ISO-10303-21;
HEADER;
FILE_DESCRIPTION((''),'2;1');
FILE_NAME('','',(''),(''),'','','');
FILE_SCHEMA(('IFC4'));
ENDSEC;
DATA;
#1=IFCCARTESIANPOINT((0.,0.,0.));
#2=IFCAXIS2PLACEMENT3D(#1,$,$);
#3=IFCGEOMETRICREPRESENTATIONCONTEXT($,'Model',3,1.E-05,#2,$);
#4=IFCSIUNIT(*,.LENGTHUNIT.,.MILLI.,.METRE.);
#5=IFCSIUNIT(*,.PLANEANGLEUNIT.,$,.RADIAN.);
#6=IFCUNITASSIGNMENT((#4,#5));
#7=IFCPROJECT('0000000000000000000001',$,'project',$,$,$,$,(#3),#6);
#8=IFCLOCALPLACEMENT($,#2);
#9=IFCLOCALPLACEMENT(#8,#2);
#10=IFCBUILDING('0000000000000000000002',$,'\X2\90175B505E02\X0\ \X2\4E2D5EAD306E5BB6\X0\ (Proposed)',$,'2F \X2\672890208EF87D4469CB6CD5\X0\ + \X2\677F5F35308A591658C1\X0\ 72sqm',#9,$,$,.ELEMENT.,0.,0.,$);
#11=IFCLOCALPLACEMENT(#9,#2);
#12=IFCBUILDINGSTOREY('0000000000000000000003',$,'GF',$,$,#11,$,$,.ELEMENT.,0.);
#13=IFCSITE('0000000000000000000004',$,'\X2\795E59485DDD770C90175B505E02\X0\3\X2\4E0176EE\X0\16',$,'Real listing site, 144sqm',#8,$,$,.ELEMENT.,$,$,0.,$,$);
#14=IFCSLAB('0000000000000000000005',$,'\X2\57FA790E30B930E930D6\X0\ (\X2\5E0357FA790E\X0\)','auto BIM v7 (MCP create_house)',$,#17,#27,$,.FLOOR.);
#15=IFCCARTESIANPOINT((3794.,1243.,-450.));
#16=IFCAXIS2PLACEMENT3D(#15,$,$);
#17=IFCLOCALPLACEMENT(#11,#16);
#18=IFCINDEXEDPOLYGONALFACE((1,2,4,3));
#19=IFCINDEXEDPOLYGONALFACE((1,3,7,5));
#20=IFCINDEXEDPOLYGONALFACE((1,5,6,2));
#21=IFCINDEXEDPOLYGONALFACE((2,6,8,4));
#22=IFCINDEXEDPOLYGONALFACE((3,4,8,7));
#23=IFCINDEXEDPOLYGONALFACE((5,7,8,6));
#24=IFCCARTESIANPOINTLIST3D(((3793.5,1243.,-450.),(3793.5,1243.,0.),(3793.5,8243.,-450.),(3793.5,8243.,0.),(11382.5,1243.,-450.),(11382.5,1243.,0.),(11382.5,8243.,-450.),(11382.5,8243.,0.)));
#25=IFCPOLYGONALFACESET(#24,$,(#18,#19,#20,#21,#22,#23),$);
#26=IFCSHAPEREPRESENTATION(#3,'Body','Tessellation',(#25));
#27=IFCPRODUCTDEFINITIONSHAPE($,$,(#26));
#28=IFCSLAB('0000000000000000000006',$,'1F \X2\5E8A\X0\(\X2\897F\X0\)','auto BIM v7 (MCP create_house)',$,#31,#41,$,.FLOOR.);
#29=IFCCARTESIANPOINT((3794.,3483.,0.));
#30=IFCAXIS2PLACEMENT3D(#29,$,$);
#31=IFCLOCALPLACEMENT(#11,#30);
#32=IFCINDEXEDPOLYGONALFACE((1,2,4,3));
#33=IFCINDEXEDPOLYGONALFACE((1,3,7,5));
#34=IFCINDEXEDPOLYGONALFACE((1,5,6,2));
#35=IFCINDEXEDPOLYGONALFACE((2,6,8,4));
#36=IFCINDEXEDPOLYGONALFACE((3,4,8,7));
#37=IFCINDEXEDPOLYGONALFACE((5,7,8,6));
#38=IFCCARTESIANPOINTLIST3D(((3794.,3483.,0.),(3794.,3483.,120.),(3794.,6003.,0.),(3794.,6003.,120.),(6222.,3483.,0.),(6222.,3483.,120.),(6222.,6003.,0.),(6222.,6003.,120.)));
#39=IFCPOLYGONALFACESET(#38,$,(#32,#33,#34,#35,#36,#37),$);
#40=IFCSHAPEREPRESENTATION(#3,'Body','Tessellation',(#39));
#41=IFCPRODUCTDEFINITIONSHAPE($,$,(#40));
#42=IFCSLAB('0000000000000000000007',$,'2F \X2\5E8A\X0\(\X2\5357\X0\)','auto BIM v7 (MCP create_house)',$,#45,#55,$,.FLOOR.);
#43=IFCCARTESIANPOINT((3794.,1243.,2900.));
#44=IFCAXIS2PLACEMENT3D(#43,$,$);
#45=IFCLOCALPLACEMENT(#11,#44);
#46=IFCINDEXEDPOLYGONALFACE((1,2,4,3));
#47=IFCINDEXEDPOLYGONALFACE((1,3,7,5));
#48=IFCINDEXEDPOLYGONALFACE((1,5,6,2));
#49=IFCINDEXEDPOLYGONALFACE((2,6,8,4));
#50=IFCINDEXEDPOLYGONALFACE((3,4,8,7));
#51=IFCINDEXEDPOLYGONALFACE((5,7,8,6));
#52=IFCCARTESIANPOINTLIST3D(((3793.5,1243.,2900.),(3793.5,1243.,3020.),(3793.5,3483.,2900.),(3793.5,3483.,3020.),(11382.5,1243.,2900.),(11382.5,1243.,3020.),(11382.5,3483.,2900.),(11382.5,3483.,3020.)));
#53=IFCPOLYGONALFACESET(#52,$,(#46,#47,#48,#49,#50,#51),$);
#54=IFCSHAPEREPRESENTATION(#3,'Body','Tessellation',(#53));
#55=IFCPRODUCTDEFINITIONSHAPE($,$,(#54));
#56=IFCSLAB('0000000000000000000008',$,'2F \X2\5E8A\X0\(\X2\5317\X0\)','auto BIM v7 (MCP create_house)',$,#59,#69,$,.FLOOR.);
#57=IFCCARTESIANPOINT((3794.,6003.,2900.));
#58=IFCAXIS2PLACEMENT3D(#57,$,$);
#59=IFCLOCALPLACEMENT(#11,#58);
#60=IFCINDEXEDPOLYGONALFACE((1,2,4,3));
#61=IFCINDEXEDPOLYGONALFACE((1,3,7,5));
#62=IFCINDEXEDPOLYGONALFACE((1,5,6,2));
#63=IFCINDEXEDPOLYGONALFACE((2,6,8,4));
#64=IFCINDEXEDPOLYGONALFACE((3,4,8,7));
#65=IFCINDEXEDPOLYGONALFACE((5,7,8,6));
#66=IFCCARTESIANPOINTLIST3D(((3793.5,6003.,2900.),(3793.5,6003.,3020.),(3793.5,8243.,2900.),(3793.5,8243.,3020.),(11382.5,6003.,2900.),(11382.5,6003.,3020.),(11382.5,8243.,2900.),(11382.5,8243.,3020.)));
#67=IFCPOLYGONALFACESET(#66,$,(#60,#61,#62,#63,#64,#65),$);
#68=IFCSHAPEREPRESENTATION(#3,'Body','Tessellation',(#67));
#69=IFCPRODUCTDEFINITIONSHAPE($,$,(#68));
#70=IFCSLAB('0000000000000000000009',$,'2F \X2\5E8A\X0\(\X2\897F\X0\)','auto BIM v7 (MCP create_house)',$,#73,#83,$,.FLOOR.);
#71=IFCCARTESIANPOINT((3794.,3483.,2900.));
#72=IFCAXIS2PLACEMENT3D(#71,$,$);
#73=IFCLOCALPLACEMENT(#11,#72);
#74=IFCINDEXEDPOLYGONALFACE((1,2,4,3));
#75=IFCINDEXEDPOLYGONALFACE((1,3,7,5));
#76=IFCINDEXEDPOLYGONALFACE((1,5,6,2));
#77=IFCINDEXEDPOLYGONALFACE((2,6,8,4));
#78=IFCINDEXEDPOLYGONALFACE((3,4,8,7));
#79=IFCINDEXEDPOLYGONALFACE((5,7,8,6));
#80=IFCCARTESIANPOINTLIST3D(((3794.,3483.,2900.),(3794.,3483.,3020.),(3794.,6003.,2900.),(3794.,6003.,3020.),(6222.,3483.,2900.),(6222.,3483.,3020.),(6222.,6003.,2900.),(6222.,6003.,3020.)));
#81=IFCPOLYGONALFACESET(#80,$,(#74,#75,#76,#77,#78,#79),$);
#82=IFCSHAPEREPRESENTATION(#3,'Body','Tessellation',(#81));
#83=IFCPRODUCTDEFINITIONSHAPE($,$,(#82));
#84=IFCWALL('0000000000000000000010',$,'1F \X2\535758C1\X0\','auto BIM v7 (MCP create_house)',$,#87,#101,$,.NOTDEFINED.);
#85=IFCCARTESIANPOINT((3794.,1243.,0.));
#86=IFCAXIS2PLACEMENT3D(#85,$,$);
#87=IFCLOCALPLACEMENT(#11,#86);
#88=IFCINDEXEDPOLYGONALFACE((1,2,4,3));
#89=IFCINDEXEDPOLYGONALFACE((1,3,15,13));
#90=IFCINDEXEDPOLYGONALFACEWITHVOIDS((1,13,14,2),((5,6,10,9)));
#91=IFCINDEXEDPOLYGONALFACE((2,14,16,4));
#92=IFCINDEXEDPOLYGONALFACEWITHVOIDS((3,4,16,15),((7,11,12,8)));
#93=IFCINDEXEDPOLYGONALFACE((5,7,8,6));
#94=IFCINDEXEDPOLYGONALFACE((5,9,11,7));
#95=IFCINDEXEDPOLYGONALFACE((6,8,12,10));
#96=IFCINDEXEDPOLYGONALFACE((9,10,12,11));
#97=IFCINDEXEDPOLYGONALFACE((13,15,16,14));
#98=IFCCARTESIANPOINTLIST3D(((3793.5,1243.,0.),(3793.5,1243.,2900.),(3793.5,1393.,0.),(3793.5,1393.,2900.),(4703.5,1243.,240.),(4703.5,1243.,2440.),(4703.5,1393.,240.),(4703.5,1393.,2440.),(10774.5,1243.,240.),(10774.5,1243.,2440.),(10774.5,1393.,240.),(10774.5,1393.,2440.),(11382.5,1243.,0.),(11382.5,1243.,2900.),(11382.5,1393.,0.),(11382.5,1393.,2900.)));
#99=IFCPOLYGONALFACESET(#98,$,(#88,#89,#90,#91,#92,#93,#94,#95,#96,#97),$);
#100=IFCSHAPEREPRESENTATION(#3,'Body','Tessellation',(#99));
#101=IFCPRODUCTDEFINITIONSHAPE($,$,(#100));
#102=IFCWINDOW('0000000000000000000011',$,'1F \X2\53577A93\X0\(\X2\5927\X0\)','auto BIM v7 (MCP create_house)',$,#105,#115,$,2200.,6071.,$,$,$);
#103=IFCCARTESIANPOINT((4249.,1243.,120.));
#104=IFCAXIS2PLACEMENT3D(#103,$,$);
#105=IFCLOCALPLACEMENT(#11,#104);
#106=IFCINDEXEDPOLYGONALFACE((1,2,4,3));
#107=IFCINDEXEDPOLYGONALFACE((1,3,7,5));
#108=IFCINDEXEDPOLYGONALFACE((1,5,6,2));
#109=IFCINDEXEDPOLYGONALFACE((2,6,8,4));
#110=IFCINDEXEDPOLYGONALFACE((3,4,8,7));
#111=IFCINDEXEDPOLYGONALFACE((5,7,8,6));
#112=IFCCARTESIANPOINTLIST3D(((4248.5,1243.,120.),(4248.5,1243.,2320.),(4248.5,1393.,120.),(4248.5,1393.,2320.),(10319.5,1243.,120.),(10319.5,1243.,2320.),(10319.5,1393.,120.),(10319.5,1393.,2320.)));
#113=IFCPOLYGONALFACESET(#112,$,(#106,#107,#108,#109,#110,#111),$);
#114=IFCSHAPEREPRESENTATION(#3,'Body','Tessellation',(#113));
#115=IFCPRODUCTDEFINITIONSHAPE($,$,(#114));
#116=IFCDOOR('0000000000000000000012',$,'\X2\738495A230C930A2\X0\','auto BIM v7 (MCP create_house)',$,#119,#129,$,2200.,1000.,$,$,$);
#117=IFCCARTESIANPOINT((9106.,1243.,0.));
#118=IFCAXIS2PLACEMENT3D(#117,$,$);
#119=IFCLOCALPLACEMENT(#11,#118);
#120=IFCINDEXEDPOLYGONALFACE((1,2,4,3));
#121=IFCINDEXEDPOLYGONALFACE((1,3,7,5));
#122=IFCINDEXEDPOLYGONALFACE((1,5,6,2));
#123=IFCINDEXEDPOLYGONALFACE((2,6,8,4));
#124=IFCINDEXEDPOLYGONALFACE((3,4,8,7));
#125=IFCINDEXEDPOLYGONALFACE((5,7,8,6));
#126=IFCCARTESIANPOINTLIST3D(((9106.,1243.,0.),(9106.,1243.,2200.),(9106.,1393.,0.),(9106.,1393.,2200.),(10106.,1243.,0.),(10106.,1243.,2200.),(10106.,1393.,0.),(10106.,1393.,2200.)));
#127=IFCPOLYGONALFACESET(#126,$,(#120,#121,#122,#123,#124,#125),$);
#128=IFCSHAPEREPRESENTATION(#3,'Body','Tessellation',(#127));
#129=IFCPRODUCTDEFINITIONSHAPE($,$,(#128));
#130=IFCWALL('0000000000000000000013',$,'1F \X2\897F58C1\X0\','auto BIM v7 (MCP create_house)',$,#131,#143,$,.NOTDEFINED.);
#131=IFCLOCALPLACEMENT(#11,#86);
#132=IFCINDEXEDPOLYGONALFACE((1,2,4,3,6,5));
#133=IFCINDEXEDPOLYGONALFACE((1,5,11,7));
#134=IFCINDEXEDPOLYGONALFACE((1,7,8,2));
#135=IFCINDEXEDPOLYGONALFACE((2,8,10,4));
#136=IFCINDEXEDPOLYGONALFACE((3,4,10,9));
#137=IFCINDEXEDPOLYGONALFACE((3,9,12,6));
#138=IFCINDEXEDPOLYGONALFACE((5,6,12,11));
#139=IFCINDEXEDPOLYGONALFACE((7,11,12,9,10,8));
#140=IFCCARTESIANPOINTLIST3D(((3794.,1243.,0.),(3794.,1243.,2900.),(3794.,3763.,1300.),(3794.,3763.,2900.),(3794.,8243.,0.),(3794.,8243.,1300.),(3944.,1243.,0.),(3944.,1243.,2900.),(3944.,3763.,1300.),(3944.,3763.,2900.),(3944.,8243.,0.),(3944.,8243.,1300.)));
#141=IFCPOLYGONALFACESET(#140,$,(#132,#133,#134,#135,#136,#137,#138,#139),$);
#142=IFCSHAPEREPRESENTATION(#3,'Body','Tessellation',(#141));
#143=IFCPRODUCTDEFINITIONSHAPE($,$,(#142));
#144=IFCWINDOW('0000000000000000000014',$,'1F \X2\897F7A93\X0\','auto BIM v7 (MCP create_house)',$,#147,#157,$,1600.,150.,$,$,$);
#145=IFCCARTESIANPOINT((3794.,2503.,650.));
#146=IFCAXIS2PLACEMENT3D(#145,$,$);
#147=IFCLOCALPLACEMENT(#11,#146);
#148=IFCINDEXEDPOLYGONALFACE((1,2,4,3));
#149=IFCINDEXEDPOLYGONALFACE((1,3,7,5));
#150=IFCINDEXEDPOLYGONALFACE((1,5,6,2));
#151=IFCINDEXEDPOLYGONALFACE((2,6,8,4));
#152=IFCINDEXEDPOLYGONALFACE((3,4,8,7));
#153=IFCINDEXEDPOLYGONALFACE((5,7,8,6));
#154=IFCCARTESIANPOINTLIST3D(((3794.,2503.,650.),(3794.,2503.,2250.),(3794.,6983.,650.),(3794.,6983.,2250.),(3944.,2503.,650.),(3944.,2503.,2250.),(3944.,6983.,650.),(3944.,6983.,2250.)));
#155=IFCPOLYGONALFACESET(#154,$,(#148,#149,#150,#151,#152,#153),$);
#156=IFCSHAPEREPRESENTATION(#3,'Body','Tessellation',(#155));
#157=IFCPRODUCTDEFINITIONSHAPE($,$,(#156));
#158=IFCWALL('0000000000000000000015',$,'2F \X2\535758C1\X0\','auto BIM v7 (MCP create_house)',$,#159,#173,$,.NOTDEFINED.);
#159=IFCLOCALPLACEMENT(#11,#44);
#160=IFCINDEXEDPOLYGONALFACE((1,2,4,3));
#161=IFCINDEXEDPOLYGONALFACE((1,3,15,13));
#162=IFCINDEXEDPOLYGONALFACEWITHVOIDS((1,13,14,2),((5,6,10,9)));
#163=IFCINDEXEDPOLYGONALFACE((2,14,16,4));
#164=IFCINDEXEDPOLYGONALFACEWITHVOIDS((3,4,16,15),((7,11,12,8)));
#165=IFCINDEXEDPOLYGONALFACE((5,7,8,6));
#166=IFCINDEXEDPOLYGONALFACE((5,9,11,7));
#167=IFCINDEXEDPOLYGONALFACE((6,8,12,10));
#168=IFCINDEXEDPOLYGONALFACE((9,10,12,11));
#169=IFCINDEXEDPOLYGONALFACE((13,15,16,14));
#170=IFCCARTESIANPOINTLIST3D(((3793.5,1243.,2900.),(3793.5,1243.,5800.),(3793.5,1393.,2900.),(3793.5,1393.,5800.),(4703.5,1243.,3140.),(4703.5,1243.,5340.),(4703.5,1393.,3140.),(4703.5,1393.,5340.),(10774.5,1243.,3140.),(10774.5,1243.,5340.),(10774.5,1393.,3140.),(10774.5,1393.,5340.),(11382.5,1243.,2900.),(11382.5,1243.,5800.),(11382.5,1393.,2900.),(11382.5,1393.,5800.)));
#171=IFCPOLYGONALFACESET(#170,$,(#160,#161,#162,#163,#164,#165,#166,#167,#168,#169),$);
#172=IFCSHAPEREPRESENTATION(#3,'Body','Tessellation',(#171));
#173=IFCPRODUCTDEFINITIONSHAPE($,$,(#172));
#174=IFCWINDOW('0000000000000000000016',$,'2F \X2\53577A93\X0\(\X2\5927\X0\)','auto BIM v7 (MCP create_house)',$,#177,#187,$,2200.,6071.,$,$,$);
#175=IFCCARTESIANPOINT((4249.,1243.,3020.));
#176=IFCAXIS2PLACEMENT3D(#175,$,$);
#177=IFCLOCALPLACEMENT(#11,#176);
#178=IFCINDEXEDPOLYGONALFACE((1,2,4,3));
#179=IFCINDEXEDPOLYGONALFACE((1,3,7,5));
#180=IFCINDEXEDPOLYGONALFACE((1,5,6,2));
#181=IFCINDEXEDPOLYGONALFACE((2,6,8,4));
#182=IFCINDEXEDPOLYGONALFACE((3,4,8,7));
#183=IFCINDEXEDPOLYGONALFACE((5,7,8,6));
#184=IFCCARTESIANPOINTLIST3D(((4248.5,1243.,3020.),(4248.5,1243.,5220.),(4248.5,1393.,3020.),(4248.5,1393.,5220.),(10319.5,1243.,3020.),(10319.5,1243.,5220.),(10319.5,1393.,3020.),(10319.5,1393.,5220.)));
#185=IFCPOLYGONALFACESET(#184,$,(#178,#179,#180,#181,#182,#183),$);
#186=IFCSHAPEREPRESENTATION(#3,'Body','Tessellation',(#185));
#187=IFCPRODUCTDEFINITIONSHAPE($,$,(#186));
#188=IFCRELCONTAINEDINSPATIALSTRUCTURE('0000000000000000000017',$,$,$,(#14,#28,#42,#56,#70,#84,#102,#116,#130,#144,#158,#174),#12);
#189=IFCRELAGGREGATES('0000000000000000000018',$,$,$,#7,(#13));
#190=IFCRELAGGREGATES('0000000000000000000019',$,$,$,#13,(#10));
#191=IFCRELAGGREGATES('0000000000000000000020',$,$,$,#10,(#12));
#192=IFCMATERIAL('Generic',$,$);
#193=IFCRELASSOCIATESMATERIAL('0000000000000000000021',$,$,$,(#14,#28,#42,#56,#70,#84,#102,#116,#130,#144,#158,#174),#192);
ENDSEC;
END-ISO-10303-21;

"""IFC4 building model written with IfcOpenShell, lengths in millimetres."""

from ifc_helpers import new_model, si_unit, frame, frame_2d, origin, place, context, project, spatial, rectangle, extrude, material, element, fill, save


model = new_model("IFC4")

# Units and contexts
model_context = context("Model", 3, precision=1e-05, world=origin())
ifc_project = project(units=[si_unit("LENGTHUNIT", "METRE", prefix="MILLI"), si_unit("PLANEANGLEUNIT", "RADIAN")], contexts=[model_context])

# Site, building, storey
site_placement = place(None, origin())
site = spatial("IfcSite", under=ifc_project, at=site_placement, Name="神奈川県逗子市3丁目16", ObjectType="Real listing site, 144sqm", CompositionType="ELEMENT", RefElevation=0.0)
building_placement = place(site_placement, origin())
building = spatial("IfcBuilding", under=site, at=building_placement, Name="逗子市 中庭の家 (Proposed)", ObjectType="2F 木造軸組構法 + 板張り外壁 72sqm", CompositionType="ELEMENT", ElevationOfRefHeight=0.0, ElevationOfTerrain=0.0)
storey_placement = place(building_placement, origin())
storey = spatial("IfcBuildingStorey", under=building, at=storey_placement, Name="GF", CompositionType="ELEMENT", Elevation=0.0)

# Slabs
ifc_material = material(Name="Generic")
slab_1_placement = place(storey_placement, frame((3794.0, 1243.0, -450.0)))
element("IfcSlab", 1, at=slab_1_placement, inside=storey, material=ifc_material, Name="基礎スラブ (布基礎)", Description="auto BIM v7 (MCP create_house)", PredefinedType="FLOOR", context=model_context, shape_type="SweptSolid", body=[
    extrude(rectangle(XDim=7589.0, YDim=7000.0, at=frame_2d((3794.0, 3500.0))), frame((3794.0, 1243.0, -450.0)), (0.0, 0.0, 1.0), 450.0),
])
slab_2_placement = place(storey_placement, frame((3794.0, 3483.0, 0.0)))
element("IfcSlab", 2, at=slab_2_placement, inside=storey, material=ifc_material, Name="1F 床(西)", Description="auto BIM v7 (MCP create_house)", PredefinedType="FLOOR", context=model_context, shape_type="SweptSolid", body=[
    extrude(rectangle(XDim=2428.0, YDim=2520.0, at=frame_2d((1214.0, 1260.0))), frame((3794.0, 3483.0, 0.0)), (0.0, 0.0, 1.0), 120.0),
])
slab_3_placement = place(storey_placement, frame((3794.0, 1243.0, 2900.0)))
element("IfcSlab", 3, at=slab_3_placement, inside=storey, material=ifc_material, Name="2F 床(南)", Description="auto BIM v7 (MCP create_house)", PredefinedType="FLOOR", context=model_context, shape_type="SweptSolid", body=[
    extrude(rectangle(XDim=7589.0, YDim=2240.0, at=frame_2d((3794.0, 1120.0))), frame((3794.0, 1243.0, 2900.0)), (0.0, 0.0, 1.0), 120.0),
])
slab_4_placement = place(storey_placement, frame((3794.0, 6003.0, 2900.0)))
element("IfcSlab", 4, at=slab_4_placement, inside=storey, material=ifc_material, Name="2F 床(北)", Description="auto BIM v7 (MCP create_house)", PredefinedType="FLOOR", context=model_context, shape_type="SweptSolid", body=[
    extrude(rectangle(XDim=7589.0, YDim=2240.0, at=frame_2d((3794.0, 1120.0))), frame((3794.0, 6003.0, 2900.0)), (0.0, 0.0, 1.0), 120.0),
])
slab_5_placement = place(storey_placement, frame((3794.0, 3483.0, 2900.0)))
element("IfcSlab", 5, at=slab_5_placement, inside=storey, material=ifc_material, Name="2F 床(西)", Description="auto BIM v7 (MCP create_house)", PredefinedType="FLOOR", context=model_context, shape_type="SweptSolid", body=[
    extrude(rectangle(XDim=2428.0, YDim=2520.0, at=frame_2d((1214.0, 1260.0))), frame((3794.0, 3483.0, 2900.0)), (0.0, 0.0, 1.0), 120.0),
])

# Wall, openings, window, door
wall_1_placement = place(storey_placement, frame((3794.0, 1243.0, 0.0)))
wall_1 = element("IfcWall", 6, at=wall_1_placement, inside=storey, material=ifc_material, Name="1F 南壁", Description="auto BIM v7 (MCP create_house)", PredefinedType="NOTDEFINED", context=model_context, shape_type="SweptSolid", body=[
    extrude(rectangle(XDim=7589.0, YDim=150.0, at=frame_2d((3794.0, 75.0))), frame((3794.0, 1243.0, 0.0)), (0.0, 0.0, 1.0), 2900.0),
])
opening_1_placement = place(storey_placement, frame((4249.0, 1243.0, 120.0)))
opening_1 = element("IfcOpeningElement", 7, at=opening_1_placement, cuts=wall_1, PredefinedType="NOTDEFINED", context=model_context, shape_type="SweptSolid", body=[
    extrude(rectangle(XDim=6071.0, YDim=150.0, at=frame_2d((3035.0, 75.0))), frame((4249.0, 1243.0, 120.0)), (0.0, 0.0, 1.0), 2200.0),
])
opening_2_placement = place(storey_placement, frame((9106.0, 1243.0, 0.0)))
opening_2 = element("IfcOpeningElement", 8, at=opening_2_placement, cuts=wall_1, PredefinedType="NOTDEFINED", context=model_context, shape_type="SweptSolid", body=[
    extrude(rectangle(XDim=1000.0, YDim=150.0, at=frame_2d((500.0, 75.0))), frame((9106.0, 1243.0, 0.0)), (0.0, 0.0, 1.0), 2200.0),
])
window_1_placement = place(storey_placement, frame((4249.0, 1243.0, 120.0)))
window_1 = element("IfcWindow", 9, at=window_1_placement, inside=storey, material=ifc_material, Name="1F 南窓(大)", Description="auto BIM v7 (MCP create_house)", OverallHeight=2200.0, OverallWidth=6071.0, context=model_context, shape_type="SweptSolid", body=[
    extrude(rectangle(XDim=6071.0, YDim=150.0, at=frame_2d((3035.0, 75.0))), frame((4249.0, 1243.0, 120.0)), (0.0, 0.0, 1.0), 2200.0),
])
fill(opening_1, window_1)
door_placement = place(storey_placement, frame((9106.0, 1243.0, 0.0)))
door = element("IfcDoor", 10, at=door_placement, inside=storey, material=ifc_material, Name="玄関ドア", Description="auto BIM v7 (MCP create_house)", OverallHeight=2200.0, OverallWidth=1000.0, context=model_context, shape_type="SweptSolid", body=[
    extrude(rectangle(XDim=1000.0, YDim=150.0, at=frame_2d((500.0, 75.0))), frame((9106.0, 1243.0, 0.0)), (0.0, 0.0, 1.0), 2200.0),
])
fill(opening_2, door)

# Walls, openings, windows
wall_2_placement = place(storey_placement, frame((3794.0, 1243.0, 0.0)))
wall_2 = element("IfcWall", 11, at=wall_2_placement, inside=storey, material=ifc_material, Name="1F 西壁", Description="auto BIM v7 (MCP create_house)", PredefinedType="NOTDEFINED", context=model_context, shape_type="SweptSolid", body=[
    extrude(rectangle(XDim=150.0, YDim=7000.0, at=frame_2d((75.0, 3500.0))), frame((3794.0, 1243.0, 0.0)), (0.0, 0.0, 1.0), 2900.0),
])
opening_3_placement = place(storey_placement, frame((3794.0, 2503.0, 650.0)))
opening_3 = element("IfcOpeningElement", 12, at=opening_3_placement, cuts=wall_2, PredefinedType="NOTDEFINED", context=model_context, shape_type="SweptSolid", body=[
    extrude(rectangle(XDim=150.0, YDim=4480.0, at=frame_2d((75.0, 2240.0))), frame((3794.0, 2503.0, 650.0)), (0.0, 0.0, 1.0), 1600.0),
])
window_2_placement = place(storey_placement, frame((3794.0, 2503.0, 650.0)))
window_2 = element("IfcWindow", 13, at=window_2_placement, inside=storey, material=ifc_material, Name="1F 西窓", Description="auto BIM v7 (MCP create_house)", OverallHeight=1600.0, OverallWidth=150.0, context=model_context, shape_type="SweptSolid", body=[
    extrude(rectangle(XDim=150.0, YDim=4480.0, at=frame_2d((75.0, 2240.0))), frame((3794.0, 2503.0, 650.0)), (0.0, 0.0, 1.0), 1600.0),
])
fill(opening_3, window_2)
wall_3_placement = place(storey_placement, frame((3794.0, 1243.0, 2900.0)))
wall_3 = element("IfcWall", 14, at=wall_3_placement, inside=storey, material=ifc_material, Name="2F 南壁", Description="auto BIM v7 (MCP create_house)", PredefinedType="NOTDEFINED", context=model_context, shape_type="SweptSolid", body=[
    extrude(rectangle(XDim=7589.0, YDim=150.0, at=frame_2d((3794.0, 75.0))), frame((3794.0, 1243.0, 2900.0)), (0.0, 0.0, 1.0), 2900.0),
])
opening_4_placement = place(storey_placement, frame((4249.0, 1243.0, 3020.0)))
opening_4 = element("IfcOpeningElement", 15, at=opening_4_placement, cuts=wall_3, PredefinedType="NOTDEFINED", context=model_context, shape_type="SweptSolid", body=[
    extrude(rectangle(XDim=6071.0, YDim=150.0, at=frame_2d((3035.0, 75.0))), frame((4249.0, 1243.0, 3020.0)), (0.0, 0.0, 1.0), 2200.0),
])
window_3_placement = place(storey_placement, frame((4249.0, 1243.0, 3020.0)))
window_3 = element("IfcWindow", 16, at=window_3_placement, inside=storey, material=ifc_material, Name="2F 南窓(大)", Description="auto BIM v7 (MCP create_house)", OverallHeight=2200.0, OverallWidth=6071.0, context=model_context, shape_type="SweptSolid", body=[
    extrude(rectangle(XDim=6071.0, YDim=150.0, at=frame_2d((3035.0, 75.0))), frame((4249.0, 1243.0, 3020.0)), (0.0, 0.0, 1.0), 2200.0),
])
fill(opening_4, window_3)

save(model, "model.ifc")
